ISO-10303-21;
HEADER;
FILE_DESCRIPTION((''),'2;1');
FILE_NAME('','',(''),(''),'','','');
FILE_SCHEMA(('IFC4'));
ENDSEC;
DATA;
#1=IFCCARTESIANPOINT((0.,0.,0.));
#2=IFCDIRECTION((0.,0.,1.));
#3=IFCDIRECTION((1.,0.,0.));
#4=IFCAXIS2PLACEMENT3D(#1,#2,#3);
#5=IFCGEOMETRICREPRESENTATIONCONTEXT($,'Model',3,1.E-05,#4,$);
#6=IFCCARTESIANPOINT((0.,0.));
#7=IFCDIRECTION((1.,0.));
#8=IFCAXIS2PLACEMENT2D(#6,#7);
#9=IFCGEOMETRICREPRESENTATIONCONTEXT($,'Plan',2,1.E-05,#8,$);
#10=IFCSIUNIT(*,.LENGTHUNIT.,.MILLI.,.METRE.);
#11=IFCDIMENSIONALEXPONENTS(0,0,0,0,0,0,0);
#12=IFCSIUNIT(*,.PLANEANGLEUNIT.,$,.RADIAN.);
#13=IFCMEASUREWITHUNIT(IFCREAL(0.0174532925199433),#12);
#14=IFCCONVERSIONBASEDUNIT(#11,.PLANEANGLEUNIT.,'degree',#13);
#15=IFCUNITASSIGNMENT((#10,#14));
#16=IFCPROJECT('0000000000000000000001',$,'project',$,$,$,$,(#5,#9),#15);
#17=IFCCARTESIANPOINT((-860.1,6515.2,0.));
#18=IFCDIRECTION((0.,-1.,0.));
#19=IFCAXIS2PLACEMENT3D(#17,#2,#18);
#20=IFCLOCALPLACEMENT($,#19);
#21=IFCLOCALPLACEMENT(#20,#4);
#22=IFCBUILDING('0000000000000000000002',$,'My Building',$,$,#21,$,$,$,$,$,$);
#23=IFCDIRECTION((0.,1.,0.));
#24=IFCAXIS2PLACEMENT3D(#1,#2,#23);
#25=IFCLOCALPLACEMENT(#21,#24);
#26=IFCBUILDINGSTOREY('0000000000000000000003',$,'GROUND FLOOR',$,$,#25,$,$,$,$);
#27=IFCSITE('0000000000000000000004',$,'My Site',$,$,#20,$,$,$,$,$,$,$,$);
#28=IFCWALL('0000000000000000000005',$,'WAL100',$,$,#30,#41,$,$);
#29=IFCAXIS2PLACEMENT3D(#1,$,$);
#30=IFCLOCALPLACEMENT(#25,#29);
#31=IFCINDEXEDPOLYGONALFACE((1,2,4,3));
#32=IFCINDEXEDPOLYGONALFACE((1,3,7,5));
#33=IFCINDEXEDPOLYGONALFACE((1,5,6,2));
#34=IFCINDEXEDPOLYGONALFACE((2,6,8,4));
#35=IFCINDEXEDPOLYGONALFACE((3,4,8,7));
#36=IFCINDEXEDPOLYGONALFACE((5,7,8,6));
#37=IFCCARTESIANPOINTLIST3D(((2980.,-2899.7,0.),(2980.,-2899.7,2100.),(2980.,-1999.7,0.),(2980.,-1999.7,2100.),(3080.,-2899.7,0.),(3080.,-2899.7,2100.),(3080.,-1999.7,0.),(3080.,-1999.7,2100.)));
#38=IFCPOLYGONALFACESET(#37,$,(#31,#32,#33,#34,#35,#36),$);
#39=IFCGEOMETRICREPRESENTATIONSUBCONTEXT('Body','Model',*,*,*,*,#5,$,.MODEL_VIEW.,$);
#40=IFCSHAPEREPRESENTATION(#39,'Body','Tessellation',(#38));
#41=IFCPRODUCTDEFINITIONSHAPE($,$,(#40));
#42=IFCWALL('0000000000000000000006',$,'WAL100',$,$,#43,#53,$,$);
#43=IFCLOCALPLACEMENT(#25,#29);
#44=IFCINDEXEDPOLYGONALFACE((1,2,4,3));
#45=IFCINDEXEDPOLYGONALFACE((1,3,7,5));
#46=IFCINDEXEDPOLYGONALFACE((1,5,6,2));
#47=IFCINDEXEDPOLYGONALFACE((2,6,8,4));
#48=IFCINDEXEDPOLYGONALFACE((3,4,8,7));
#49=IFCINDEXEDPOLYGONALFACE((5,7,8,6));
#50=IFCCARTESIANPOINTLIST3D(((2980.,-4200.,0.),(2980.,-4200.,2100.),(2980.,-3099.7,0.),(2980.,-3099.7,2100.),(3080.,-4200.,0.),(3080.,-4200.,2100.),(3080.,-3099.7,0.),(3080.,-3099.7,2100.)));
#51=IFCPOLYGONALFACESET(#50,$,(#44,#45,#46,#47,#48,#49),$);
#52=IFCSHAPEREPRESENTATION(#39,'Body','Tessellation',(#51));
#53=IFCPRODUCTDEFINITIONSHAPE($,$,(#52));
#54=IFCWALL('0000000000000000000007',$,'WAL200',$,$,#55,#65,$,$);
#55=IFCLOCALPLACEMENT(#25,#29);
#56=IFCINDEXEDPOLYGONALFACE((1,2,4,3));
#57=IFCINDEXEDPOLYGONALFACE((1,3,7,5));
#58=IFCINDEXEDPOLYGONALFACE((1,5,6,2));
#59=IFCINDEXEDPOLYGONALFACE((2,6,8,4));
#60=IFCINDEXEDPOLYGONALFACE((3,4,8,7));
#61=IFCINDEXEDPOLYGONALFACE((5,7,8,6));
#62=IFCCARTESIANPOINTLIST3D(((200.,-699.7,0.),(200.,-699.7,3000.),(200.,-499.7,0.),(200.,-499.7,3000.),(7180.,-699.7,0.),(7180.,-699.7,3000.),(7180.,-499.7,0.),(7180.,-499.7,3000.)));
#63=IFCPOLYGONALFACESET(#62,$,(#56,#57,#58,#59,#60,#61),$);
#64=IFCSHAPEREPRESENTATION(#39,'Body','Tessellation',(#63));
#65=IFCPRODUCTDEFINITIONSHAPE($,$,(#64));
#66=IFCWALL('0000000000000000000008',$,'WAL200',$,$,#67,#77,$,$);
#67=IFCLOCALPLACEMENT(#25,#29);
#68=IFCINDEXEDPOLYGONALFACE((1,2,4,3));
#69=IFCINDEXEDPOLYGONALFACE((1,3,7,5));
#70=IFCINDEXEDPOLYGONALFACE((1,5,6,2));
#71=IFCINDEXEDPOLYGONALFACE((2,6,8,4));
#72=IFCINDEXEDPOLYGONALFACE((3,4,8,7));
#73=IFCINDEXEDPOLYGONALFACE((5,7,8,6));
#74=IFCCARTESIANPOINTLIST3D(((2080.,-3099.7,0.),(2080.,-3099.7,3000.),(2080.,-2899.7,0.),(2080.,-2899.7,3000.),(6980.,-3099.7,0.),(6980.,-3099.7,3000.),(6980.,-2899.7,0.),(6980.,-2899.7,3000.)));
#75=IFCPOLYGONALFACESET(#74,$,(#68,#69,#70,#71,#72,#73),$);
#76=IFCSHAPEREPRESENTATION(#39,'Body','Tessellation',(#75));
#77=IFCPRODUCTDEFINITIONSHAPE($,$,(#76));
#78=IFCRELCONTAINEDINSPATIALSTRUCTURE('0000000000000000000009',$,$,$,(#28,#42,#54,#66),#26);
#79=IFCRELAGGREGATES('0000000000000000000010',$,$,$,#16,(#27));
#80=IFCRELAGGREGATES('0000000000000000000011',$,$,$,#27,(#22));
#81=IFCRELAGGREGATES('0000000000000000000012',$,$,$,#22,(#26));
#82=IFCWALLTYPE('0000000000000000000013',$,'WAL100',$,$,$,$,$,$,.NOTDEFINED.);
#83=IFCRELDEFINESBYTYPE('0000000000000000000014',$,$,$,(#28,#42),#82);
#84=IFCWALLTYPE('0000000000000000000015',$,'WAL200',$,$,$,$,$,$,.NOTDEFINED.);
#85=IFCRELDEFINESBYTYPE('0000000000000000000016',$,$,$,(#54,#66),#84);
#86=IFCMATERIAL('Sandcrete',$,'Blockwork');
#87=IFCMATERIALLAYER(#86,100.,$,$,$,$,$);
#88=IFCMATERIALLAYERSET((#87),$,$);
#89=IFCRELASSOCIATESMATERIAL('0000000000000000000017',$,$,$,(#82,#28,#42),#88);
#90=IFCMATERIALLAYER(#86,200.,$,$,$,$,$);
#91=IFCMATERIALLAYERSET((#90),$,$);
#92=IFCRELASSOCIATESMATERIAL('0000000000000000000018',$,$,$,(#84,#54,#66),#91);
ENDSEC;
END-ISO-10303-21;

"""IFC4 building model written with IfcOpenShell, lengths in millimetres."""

from ifc_helpers import new_model, entity, si_unit, converted_unit, frame, origin_with_axes, origin_2d_with_axis, place, context, subcontext, project, spatial, indexed_curve, outline, extrude, material, layer, layer_set, layer_usage, type_object, element, save


model = new_model("IFC4")

# Units and contexts
model_context = context("Model", 3, precision=1e-05, world=origin_with_axes())
plan_context = context("Plan", 2, precision=1e-05, world=origin_2d_with_axis())
body_context_1 = subcontext(model_context, "Body", "Model", "MODEL_VIEW")
ifc_project = project(units=[si_unit("LENGTHUNIT", "METRE", prefix="MILLI"), converted_unit("PLANEANGLEUNIT", "degree", entity("IfcReal", 0.0174532925199433), si_unit("PLANEANGLEUNIT", "RADIAN"), dimensions=[0, 0, 0, 0, 0, 0, 0])], contexts=[model_context, plan_context])

# Site, building, storey
site_placement = place(None, frame((-860.1, 6515.2, 0.0), z_axis=(0.0, 0.0, 1.0), x_axis=(0.0, -1.0, 0.0)))
site = spatial("IfcSite", under=ifc_project, at=site_placement, Name="My Site")
building_placement = place(site_placement, frame((0.0, 0.0, 0.0), z_axis=(0.0, 0.0, 1.0), x_axis=(1.0, 0.0, 0.0)))
building = spatial("IfcBuilding", under=site, at=building_placement, Name="My Building")
storey_placement = place(building_placement, frame((0.0, 0.0, 0.0), z_axis=(0.0, 0.0, 1.0), x_axis=(0.0, 1.0, 0.0)))
storey = spatial("IfcBuildingStorey", under=building, at=storey_placement, Name="GROUND FLOOR")

# Walls
ifc_material_1 = material(Name="Sandcrete", Category="Blockwork")
ifc_layer_1 = layer(ifc_material_1, 100.0)
ifc_layer_set_1 = layer_set([ifc_layer_1])
ifc_layer_usage_1 = layer_usage(ifc_layer_set_1, "AXIS2", "POSITIVE", 0.0)
wall_type_1 = type_object("IfcWallType", Name="WAL100", PredefinedType="NOTDEFINED", material=ifc_layer_set_1)
wall_1_placement = place(storey_placement, frame((2980.0, -1999.7, 0.0), z_axis=(0.0, 0.0, 1.0), x_axis=(-0.000001, -1.0, 0.0)))
element("IfcWall", 1, at=wall_1_placement, inside=storey, type_object=wall_type_1, material=ifc_layer_usage_1, Name="WAL100", context=body_context_1, shape_type="SweptSolid", body=[
    extrude(outline(indexed_curve([(0.0, 0.0), (0.0, 100.0), (900.0, 100.0), (900.0, 0.0), (0.0, 0.0)], self_intersect=False)), origin_with_axes(), (0.0, 0.0, 1.0), 2100.0),
])
ifc_layer_usage_2 = layer_usage(ifc_layer_set_1, "AXIS2", "POSITIVE", 0.0)
wall_2_placement = place(storey_placement, frame((2980.0, -3099.7, 0.0), z_axis=(0.0, 0.0, 1.0), x_axis=(-0.000001, -1.0, 0.0)))
element("IfcWall", 2, at=wall_2_placement, inside=storey, type_object=wall_type_1, material=ifc_layer_usage_2, Name="WAL100", context=body_context_1, shape_type="SweptSolid", body=[
    extrude(outline(indexed_curve([(0.0, 0.0), (0.0, 100.0), (1100.3, 100.0), (1100.3, 0.0), (0.0, 0.0)], self_intersect=False)), origin_with_axes(), (0.0, 0.0, 1.0), 2100.0),
])
ifc_layer_2 = layer(ifc_material_1, 200.0)
ifc_layer_set_2 = layer_set([ifc_layer_2])
ifc_layer_usage_3 = layer_usage(ifc_layer_set_2, "AXIS2", "POSITIVE", 0.0)
wall_type_2 = type_object("IfcWallType", Name="WAL200", PredefinedType="NOTDEFINED", material=ifc_layer_set_2)
wall_3_placement = place(storey_placement, frame((200.0, -699.7, 0.0), z_axis=(0.0, 0.0, 1.0), x_axis=(1.0, -0.000001, 0.0)))
element("IfcWall", 3, at=wall_3_placement, inside=storey, type_object=wall_type_2, material=ifc_layer_usage_3, Name="WAL200", context=body_context_1, shape_type="SweptSolid", body=[
    extrude(outline(indexed_curve([(0.0, 0.0), (0.0, 200.0), (6980.0, 200.0), (6980.0, 0.0), (0.0, 0.0)], self_intersect=False)), origin_with_axes(), (0.0, 0.0, 1.0), 3000.0),
])
ifc_layer_usage_4 = layer_usage(ifc_layer_set_2, "AXIS2", "POSITIVE", 0.0)
wall_4_placement = place(storey_placement, frame((2080.0, -3099.7, 0.0), z_axis=(0.0, 0.0, 1.0), x_axis=(1.0, 0.0, 0.0)))
element("IfcWall", 4, at=wall_4_placement, inside=storey, type_object=wall_type_2, material=ifc_layer_usage_4, Name="WAL200", context=body_context_1, shape_type="SweptSolid", body=[
    extrude(outline(indexed_curve([(0.0, 0.0), (0.0, 200.0), (4900.0, 200.0), (4900.0, 0.0), (0.0, 0.0)], self_intersect=False)), origin_with_axes(), (0.0, 0.0, 1.0), 3000.0),
])

save(model, "model.ifc")
